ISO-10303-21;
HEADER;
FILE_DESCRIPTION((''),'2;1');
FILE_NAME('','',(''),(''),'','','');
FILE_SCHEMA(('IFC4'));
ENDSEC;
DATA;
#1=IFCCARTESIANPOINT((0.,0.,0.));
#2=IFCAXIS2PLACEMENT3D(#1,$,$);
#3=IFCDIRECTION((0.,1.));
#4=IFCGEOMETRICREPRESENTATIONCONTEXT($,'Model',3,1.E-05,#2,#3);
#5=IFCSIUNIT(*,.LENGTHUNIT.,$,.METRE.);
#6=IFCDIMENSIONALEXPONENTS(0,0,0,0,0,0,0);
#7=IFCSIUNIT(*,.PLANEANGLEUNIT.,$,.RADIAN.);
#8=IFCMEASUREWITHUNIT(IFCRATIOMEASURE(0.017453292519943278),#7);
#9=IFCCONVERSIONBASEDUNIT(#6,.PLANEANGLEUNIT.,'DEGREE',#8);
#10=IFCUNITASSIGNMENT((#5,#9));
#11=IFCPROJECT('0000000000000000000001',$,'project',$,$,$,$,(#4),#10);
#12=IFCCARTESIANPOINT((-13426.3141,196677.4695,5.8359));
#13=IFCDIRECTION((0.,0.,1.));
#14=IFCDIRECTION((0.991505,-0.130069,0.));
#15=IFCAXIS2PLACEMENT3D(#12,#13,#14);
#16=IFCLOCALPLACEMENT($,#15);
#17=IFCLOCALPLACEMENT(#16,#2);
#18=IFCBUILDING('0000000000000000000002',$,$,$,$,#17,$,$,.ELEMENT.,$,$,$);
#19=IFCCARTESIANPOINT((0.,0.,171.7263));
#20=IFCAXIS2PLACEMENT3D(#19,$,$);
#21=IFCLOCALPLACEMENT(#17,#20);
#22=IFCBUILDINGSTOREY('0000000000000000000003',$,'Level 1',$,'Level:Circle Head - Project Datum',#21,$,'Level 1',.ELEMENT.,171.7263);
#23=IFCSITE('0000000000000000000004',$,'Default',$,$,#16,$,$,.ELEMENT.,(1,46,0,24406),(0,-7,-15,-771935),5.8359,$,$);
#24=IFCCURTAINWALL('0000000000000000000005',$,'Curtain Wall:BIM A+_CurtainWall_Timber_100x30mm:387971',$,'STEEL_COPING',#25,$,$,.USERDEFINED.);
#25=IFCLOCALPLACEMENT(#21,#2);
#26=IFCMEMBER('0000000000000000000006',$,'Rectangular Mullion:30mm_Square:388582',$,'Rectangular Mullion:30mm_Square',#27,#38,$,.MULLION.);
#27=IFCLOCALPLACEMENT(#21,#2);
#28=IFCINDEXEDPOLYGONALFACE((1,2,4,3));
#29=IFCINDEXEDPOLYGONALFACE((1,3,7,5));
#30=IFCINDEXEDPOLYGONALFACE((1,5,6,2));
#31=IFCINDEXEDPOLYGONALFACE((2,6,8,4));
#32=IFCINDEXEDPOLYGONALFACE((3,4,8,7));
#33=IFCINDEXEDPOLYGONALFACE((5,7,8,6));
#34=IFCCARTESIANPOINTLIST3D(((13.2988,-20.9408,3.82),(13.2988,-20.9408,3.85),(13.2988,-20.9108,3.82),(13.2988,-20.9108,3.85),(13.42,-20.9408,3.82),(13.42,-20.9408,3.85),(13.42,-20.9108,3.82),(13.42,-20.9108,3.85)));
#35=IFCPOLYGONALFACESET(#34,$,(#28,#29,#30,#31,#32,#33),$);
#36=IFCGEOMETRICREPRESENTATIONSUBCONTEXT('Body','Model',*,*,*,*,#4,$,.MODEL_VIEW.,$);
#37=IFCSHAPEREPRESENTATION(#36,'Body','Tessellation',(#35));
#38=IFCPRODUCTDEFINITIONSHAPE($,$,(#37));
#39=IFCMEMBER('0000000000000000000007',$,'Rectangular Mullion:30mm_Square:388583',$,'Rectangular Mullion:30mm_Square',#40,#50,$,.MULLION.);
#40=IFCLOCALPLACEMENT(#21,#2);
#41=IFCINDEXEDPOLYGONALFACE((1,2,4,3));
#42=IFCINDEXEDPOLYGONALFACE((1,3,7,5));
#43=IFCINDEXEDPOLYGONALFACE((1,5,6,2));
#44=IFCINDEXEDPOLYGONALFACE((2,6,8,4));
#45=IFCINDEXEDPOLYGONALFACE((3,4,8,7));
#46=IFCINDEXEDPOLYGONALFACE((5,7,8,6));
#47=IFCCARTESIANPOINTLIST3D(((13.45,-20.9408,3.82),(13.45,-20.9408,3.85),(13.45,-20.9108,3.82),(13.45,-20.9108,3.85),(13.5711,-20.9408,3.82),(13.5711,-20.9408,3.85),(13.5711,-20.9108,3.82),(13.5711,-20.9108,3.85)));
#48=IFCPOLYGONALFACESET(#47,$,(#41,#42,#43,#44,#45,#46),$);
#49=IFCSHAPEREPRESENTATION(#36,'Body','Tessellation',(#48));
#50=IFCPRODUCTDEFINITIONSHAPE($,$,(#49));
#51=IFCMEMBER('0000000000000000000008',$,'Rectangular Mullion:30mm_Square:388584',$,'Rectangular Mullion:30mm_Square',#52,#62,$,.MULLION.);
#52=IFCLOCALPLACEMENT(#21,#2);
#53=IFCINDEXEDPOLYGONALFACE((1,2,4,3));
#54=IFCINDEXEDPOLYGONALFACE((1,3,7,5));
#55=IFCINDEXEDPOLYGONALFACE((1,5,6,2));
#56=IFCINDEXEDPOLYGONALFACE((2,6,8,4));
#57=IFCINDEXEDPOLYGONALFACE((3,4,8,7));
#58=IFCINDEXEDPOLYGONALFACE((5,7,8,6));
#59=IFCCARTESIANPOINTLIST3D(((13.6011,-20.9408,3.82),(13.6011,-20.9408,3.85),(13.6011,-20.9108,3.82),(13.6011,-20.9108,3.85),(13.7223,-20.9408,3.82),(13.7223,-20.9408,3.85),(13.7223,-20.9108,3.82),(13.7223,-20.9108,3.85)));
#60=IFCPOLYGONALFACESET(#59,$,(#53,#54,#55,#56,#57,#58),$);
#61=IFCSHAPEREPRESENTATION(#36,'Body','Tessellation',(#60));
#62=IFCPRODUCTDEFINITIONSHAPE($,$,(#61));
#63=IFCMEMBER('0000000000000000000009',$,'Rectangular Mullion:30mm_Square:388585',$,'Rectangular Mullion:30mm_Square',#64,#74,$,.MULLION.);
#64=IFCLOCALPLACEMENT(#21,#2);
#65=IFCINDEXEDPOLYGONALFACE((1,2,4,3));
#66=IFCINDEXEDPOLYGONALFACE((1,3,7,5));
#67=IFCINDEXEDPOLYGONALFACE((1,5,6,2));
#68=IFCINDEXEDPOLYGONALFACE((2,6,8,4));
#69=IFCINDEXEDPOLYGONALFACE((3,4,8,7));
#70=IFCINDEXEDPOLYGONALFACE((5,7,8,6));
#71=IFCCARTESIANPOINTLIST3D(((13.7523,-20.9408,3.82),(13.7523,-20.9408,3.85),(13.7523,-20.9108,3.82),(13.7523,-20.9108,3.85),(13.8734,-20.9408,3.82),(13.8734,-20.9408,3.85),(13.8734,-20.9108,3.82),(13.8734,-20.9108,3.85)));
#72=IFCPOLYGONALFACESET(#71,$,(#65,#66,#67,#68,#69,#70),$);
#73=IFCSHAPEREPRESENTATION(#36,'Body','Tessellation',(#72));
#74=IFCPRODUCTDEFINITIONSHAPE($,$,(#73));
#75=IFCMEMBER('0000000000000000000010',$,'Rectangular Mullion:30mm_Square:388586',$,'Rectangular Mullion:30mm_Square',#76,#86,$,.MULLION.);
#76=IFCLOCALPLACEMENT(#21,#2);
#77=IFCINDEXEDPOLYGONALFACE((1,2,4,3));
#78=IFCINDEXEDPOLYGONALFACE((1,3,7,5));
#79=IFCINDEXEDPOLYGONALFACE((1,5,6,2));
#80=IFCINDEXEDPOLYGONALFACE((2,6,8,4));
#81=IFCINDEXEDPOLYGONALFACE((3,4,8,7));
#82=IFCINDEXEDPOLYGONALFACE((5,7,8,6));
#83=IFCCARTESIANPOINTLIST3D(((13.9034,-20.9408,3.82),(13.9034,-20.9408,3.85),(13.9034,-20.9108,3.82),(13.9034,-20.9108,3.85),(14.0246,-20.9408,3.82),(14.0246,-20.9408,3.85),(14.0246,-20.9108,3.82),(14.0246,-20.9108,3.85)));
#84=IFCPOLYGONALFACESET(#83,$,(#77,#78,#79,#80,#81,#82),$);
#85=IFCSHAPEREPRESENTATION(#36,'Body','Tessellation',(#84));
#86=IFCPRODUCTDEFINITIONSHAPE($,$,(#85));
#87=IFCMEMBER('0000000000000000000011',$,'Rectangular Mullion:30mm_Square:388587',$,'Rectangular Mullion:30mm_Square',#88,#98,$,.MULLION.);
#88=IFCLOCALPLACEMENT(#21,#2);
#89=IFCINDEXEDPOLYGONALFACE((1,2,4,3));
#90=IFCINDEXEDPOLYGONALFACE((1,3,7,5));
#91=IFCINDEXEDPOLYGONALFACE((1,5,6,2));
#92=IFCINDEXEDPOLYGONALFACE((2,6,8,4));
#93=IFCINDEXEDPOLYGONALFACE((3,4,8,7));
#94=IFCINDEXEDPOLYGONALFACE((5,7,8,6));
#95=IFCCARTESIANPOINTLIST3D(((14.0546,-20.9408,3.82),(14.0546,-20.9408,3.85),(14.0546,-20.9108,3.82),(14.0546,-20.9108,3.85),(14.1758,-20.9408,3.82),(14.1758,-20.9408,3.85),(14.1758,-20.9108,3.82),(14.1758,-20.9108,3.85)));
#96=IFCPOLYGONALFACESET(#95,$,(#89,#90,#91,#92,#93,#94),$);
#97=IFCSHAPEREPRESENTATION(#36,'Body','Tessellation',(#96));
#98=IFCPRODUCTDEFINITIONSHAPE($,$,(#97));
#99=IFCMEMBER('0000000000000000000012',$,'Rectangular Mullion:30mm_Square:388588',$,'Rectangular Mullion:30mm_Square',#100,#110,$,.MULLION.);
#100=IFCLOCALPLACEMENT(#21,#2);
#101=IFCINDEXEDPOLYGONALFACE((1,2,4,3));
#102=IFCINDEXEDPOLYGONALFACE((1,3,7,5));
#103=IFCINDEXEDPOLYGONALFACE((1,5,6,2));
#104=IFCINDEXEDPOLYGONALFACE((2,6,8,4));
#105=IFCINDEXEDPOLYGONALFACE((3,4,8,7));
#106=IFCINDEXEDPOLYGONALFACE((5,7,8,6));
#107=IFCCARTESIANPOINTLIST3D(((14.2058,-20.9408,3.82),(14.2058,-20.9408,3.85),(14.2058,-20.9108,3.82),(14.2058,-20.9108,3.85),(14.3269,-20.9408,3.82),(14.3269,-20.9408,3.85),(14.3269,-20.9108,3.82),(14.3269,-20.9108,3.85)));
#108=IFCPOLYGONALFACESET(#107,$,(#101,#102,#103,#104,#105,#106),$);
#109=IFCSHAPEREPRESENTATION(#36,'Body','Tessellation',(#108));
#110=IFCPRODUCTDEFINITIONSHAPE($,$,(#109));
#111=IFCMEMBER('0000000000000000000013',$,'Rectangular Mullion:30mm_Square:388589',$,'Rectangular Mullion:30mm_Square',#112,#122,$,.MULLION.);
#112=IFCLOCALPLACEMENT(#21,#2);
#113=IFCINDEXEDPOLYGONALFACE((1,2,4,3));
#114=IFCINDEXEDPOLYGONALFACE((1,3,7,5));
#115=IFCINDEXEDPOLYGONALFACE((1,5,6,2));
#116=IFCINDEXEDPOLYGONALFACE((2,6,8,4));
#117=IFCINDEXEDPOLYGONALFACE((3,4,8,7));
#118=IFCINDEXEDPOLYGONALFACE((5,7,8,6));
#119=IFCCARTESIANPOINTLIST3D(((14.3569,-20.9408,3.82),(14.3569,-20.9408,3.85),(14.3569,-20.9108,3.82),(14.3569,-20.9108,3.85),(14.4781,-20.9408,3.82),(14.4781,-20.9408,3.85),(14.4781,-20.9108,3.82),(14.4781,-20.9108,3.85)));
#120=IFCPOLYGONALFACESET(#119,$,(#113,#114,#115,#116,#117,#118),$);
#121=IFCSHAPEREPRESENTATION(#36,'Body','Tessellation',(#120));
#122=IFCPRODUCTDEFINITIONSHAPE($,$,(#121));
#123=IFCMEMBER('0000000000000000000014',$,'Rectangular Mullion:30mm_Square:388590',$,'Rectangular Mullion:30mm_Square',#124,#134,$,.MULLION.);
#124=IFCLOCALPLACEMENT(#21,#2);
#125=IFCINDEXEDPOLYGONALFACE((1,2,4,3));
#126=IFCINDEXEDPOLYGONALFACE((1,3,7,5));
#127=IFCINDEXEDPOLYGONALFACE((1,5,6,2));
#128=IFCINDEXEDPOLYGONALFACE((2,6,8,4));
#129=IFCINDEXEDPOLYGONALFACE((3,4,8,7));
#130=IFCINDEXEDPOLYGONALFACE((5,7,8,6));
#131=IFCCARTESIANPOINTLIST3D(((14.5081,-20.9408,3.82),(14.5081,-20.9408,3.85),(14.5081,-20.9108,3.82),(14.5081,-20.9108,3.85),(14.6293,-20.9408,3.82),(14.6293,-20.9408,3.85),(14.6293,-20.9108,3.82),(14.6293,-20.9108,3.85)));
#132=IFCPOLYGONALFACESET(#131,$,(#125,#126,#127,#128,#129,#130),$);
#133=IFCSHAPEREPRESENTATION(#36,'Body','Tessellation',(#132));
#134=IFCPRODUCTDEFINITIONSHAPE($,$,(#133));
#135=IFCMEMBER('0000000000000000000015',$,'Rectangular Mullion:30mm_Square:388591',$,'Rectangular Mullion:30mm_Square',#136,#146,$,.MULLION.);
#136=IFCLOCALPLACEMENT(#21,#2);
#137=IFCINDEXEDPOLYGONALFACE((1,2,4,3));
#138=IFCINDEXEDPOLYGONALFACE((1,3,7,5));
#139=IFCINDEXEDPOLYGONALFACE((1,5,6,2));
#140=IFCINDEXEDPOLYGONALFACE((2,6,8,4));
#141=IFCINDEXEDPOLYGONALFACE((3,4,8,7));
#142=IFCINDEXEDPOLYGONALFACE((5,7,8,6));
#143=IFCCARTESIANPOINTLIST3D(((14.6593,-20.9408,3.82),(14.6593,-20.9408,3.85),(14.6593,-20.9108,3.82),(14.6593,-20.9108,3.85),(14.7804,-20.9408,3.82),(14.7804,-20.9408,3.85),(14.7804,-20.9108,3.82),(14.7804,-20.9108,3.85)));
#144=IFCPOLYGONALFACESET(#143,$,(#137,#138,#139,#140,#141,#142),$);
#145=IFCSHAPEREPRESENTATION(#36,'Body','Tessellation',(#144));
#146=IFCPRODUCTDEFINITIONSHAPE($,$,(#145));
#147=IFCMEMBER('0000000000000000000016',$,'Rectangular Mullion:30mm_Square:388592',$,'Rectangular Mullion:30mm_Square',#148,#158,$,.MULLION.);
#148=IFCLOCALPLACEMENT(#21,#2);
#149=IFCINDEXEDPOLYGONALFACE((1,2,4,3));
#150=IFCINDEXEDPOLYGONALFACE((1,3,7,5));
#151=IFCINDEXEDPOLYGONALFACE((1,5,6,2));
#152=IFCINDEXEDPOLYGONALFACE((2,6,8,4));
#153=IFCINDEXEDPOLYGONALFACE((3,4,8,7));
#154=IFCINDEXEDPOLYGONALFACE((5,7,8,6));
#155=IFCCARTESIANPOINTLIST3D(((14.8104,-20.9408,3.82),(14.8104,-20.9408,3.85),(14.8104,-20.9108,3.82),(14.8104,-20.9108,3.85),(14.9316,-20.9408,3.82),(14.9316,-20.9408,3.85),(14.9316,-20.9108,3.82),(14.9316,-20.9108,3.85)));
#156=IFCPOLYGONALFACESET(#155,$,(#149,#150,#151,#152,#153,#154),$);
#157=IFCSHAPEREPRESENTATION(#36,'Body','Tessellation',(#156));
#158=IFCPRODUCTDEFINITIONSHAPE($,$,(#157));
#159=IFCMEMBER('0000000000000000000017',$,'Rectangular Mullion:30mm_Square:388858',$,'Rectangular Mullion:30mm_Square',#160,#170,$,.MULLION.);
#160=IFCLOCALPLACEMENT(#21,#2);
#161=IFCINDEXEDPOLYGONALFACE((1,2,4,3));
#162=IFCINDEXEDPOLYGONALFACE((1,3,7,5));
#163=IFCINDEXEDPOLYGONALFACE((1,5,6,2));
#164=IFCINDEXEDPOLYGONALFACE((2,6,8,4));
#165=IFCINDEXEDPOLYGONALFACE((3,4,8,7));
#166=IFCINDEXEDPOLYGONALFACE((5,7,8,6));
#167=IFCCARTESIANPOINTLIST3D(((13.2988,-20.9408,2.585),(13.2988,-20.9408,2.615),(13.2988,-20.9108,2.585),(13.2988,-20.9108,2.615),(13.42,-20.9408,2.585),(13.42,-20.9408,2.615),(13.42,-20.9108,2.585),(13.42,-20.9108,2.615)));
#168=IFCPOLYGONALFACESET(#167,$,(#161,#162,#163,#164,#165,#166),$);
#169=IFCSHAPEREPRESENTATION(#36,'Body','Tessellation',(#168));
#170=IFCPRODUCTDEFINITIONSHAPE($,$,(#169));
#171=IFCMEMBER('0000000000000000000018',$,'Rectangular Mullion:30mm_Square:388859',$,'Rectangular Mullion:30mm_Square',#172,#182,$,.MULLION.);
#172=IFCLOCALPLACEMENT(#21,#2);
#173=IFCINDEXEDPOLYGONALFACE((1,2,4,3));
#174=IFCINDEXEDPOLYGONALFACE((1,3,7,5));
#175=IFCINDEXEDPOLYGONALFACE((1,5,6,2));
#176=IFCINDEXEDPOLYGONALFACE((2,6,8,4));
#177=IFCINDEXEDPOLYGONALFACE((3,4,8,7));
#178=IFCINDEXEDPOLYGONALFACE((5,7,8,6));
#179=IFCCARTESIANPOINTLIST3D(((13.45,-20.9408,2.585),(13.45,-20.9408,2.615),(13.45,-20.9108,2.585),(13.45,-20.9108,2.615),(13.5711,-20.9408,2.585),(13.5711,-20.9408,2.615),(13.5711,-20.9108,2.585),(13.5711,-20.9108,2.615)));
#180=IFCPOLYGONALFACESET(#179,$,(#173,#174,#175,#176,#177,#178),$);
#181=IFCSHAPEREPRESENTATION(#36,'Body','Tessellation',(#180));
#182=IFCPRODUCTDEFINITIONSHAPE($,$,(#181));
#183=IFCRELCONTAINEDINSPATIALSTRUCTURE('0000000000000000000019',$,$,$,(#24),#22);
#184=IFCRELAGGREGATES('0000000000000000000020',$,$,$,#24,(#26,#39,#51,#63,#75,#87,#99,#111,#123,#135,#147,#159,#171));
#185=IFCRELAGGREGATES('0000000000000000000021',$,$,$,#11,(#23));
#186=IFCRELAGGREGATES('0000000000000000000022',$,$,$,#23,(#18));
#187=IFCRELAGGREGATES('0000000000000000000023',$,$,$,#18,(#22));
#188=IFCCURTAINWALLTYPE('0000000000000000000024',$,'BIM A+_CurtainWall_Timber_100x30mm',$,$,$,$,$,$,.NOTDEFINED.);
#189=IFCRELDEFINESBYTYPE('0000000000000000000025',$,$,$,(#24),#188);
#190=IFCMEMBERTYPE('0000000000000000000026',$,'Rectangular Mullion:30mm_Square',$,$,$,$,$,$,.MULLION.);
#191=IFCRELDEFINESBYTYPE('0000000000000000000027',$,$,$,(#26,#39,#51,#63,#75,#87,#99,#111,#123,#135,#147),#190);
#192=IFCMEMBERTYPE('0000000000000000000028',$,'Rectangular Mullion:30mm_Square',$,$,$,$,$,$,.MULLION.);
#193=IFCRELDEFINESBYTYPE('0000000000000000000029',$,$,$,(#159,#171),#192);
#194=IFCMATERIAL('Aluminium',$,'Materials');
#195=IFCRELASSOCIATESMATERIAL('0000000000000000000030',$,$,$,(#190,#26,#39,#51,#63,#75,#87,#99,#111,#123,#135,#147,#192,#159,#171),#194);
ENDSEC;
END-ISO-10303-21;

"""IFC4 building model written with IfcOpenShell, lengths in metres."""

from ifc_helpers import new_model, entity, si_unit, converted_unit, direction, frame, origin, place, context, subcontext, project, spatial, indexed_curve, outline, extrude, source, transform, mapped, material, type_object, type_shapes, element, aggregate, save


model = new_model("IFC4")

# Units and contexts
model_context = context("Model", 3, precision=1e-05, world=origin(), true_north=direction((0.0, 1.0)))
body_context = subcontext(model_context, "Body", "Model", "MODEL_VIEW")
ifc_project = project(units=[si_unit("LENGTHUNIT", "METRE"), converted_unit("PLANEANGLEUNIT", "DEGREE", entity("IfcRatioMeasure", 0.017453292519943278), si_unit("PLANEANGLEUNIT", "RADIAN"), dimensions=[0, 0, 0, 0, 0, 0, 0])], contexts=[model_context])

# Site, building, storey
site_placement = place(None, frame((-13426.3141, 196677.4695, 5.8359), z_axis=(0.0, 0.0, 1.0), x_axis=(0.991505, -0.130069, 0.0)))
site = spatial("IfcSite", under=ifc_project, at=site_placement, Name="Default", CompositionType="ELEMENT", RefLatitude=(1, 46, 0, 24406), RefLongitude=(0, -7, -15, -771935), RefElevation=5.8359)
building_placement = place(site_placement, origin())
building = spatial("IfcBuilding", under=site, at=building_placement, CompositionType="ELEMENT")
storey_placement = place(building_placement, frame((0.0, 0.0, 171.7263)))
storey = spatial("IfcBuildingStorey", under=building, at=storey_placement, Name="Level 1", ObjectType="Level:Circle Head - Project Datum", LongName="Level 1", CompositionType="ELEMENT", Elevation=171.7263)

# Curtain wall, members
curtain_wall_type = type_object("IfcCurtainWallType", Name="BIM A+_CurtainWall_Timber_100x30mm", PredefinedType="NOTDEFINED")
curtain_wall_placement = place(storey_placement, frame((0.0, 0.0, -171.7263)))
curtain_wall = element("IfcCurtainWall", 1, at=curtain_wall_placement, inside=storey, type_object=curtain_wall_type, Name="Curtain Wall:BIM A+_CurtainWall_Timber_100x30mm:387971", ObjectType="STEEL_COPING", PredefinedType="USERDEFINED")
ifc_material_1 = material(Name="Aluminium", Category="Materials")
member_type_1 = type_object("IfcMemberType", Name="Rectangular Mullion:30mm_Square", PredefinedType="MULLION", material=ifc_material_1)
shared_shape_1 = source(origin(), body_context, "Body", "SweptSolid", [
    extrude(outline(indexed_curve([(-0.015, -0.015), (0.015, -0.015), (0.015, 0.015), (-0.015, 0.015), (-0.015, -0.015)], self_intersect=False)), frame((-0.015, 0.0, -0.1212), z_axis=(0.0, 0.0, 1.0), x_axis=(0.0, -1.0, 0.0)), (0.0, 0.0, 1.0), 0.1212),
])
type_shapes(member_type_1, [shared_shape_1])
member_1_placement = place(curtain_wall_placement, frame((13.42, -20.9258, 175.5763), z_axis=(1.0, 0.0, 0.0), x_axis=(0.0, 0.0, 1.0)))
member_1 = element("IfcMember", 2, at=member_1_placement, type_object=member_type_1, material=ifc_material_1, Name="Rectangular Mullion:30mm_Square:388582", ObjectType="Rectangular Mullion:30mm_Square", PredefinedType="MULLION", context=body_context, shape_type="MappedRepresentation", body=[
    mapped(shared_shape_1, transform((0.0, 0.0, 0.0), scale=1.0)),
])
member_2_placement = place(curtain_wall_placement, frame((13.5711, -20.9258, 175.5763), z_axis=(1.0, 0.0, 0.0), x_axis=(0.0, 0.0, 1.0)))
member_2 = element("IfcMember", 3, at=member_2_placement, type_object=member_type_1, material=ifc_material_1, Name="Rectangular Mullion:30mm_Square:388583", ObjectType="Rectangular Mullion:30mm_Square", PredefinedType="MULLION", context=body_context, shape_type="MappedRepresentation", body=[
    mapped(shared_shape_1, transform((0.0, 0.0, 0.0), scale=1.0)),
])
member_3_placement = place(curtain_wall_placement, frame((13.7223, -20.9258, 175.5763), z_axis=(1.0, 0.0, 0.0), x_axis=(0.0, 0.0, 1.0)))
member_3 = element("IfcMember", 4, at=member_3_placement, type_object=member_type_1, material=ifc_material_1, Name="Rectangular Mullion:30mm_Square:388584", ObjectType="Rectangular Mullion:30mm_Square", PredefinedType="MULLION", context=body_context, shape_type="MappedRepresentation", body=[
    mapped(shared_shape_1, transform((0.0, 0.0, 0.0), scale=1.0)),
])
member_4_placement = place(curtain_wall_placement, frame((13.8734, -20.9258, 175.5763), z_axis=(1.0, 0.0, 0.0), x_axis=(0.0, 0.0, 1.0)))
member_4 = element("IfcMember", 5, at=member_4_placement, type_object=member_type_1, material=ifc_material_1, Name="Rectangular Mullion:30mm_Square:388585", ObjectType="Rectangular Mullion:30mm_Square", PredefinedType="MULLION", context=body_context, shape_type="MappedRepresentation", body=[
    mapped(shared_shape_1, transform((0.0, 0.0, 0.0), scale=1.0)),
])
member_5_placement = place(curtain_wall_placement, frame((14.0246, -20.9258, 175.5763), z_axis=(1.0, 0.0, 0.0), x_axis=(0.0, 0.0, 1.0)))
member_5 = element("IfcMember", 6, at=member_5_placement, type_object=member_type_1, material=ifc_material_1, Name="Rectangular Mullion:30mm_Square:388586", ObjectType="Rectangular Mullion:30mm_Square", PredefinedType="MULLION", context=body_context, shape_type="MappedRepresentation", body=[
    mapped(shared_shape_1, transform((0.0, 0.0, 0.0), scale=1.0)),
])
member_6_placement = place(curtain_wall_placement, frame((14.1758, -20.9258, 175.5763), z_axis=(1.0, 0.0, 0.0), x_axis=(0.0, 0.0, 1.0)))
member_6 = element("IfcMember", 7, at=member_6_placement, type_object=member_type_1, material=ifc_material_1, Name="Rectangular Mullion:30mm_Square:388587", ObjectType="Rectangular Mullion:30mm_Square", PredefinedType="MULLION", context=body_context, shape_type="MappedRepresentation", body=[
    mapped(shared_shape_1, transform((0.0, 0.0, 0.0), scale=1.0)),
])
member_7_placement = place(curtain_wall_placement, frame((14.3269, -20.9258, 175.5763), z_axis=(1.0, 0.0, 0.0), x_axis=(0.0, 0.0, 1.0)))
member_7 = element("IfcMember", 8, at=member_7_placement, type_object=member_type_1, material=ifc_material_1, Name="Rectangular Mullion:30mm_Square:388588", ObjectType="Rectangular Mullion:30mm_Square", PredefinedType="MULLION", context=body_context, shape_type="MappedRepresentation", body=[
    mapped(shared_shape_1, transform((0.0, 0.0, 0.0), scale=1.0)),
])
member_8_placement = place(curtain_wall_placement, frame((14.4781, -20.9258, 175.5763), z_axis=(1.0, 0.0, 0.0), x_axis=(0.0, 0.0, 1.0)))
member_8 = element("IfcMember", 9, at=member_8_placement, type_object=member_type_1, material=ifc_material_1, Name="Rectangular Mullion:30mm_Square:388589", ObjectType="Rectangular Mullion:30mm_Square", PredefinedType="MULLION", context=body_context, shape_type="MappedRepresentation", body=[
    mapped(shared_shape_1, transform((0.0, 0.0, 0.0), scale=1.0)),
])
member_9_placement = place(curtain_wall_placement, frame((14.6293, -20.9258, 175.5763), z_axis=(1.0, 0.0, 0.0), x_axis=(0.0, 0.0, 1.0)))
member_9 = element("IfcMember", 10, at=member_9_placement, type_object=member_type_1, material=ifc_material_1, Name="Rectangular Mullion:30mm_Square:388590", ObjectType="Rectangular Mullion:30mm_Square", PredefinedType="MULLION", context=body_context, shape_type="MappedRepresentation", body=[
    mapped(shared_shape_1, transform((0.0, 0.0, 0.0), scale=1.0)),
])
member_10_placement = place(curtain_wall_placement, frame((14.7804, -20.9258, 175.5763), z_axis=(1.0, 0.0, 0.0), x_axis=(0.0, 0.0, 1.0)))
member_10 = element("IfcMember", 11, at=member_10_placement, type_object=member_type_1, material=ifc_material_1, Name="Rectangular Mullion:30mm_Square:388591", ObjectType="Rectangular Mullion:30mm_Square", PredefinedType="MULLION", context=body_context, shape_type="MappedRepresentation", body=[
    mapped(shared_shape_1, transform((0.0, 0.0, 0.0), scale=1.0)),
])
member_11_placement = place(curtain_wall_placement, frame((14.9316, -20.9258, 175.5763), z_axis=(1.0, 0.0, 0.0), x_axis=(0.0, 0.0, 1.0)))
member_11 = element("IfcMember", 12, at=member_11_placement, type_object=member_type_1, material=ifc_material_1, Name="Rectangular Mullion:30mm_Square:388592", ObjectType="Rectangular Mullion:30mm_Square", PredefinedType="MULLION", context=body_context, shape_type="MappedRepresentation", body=[
    mapped(shared_shape_1, transform((0.0, 0.0, 0.0), scale=1.0)),
])
member_type_2 = type_object("IfcMemberType", Name="Rectangular Mullion:30mm_Square", PredefinedType="MULLION", material=ifc_material_1)
shared_shape_2 = source(origin(), body_context, "Body", "SweptSolid", [
    extrude(outline(indexed_curve([(-0.015, -0.015), (0.015, -0.015), (0.015, 0.015), (-0.015, 0.015), (-0.015, -0.015)], self_intersect=False)), frame((0.0, 0.0, -0.1212), z_axis=(0.0, 0.0, 1.0), x_axis=(0.0, -1.0, 0.0)), (0.0, 0.0, 1.0), 0.1212),
])
type_shapes(member_type_2, [shared_shape_2])
member_12_placement = place(curtain_wall_placement, frame((13.42, -20.9258, 174.3263), z_axis=(1.0, 0.0, 0.0), x_axis=(0.0, 0.0, 1.0)))
member_12 = element("IfcMember", 13, at=member_12_placement, type_object=member_type_2, material=ifc_material_1, Name="Rectangular Mullion:30mm_Square:388858", ObjectType="Rectangular Mullion:30mm_Square", PredefinedType="MULLION", context=body_context, shape_type="MappedRepresentation", body=[
    mapped(shared_shape_2, transform((0.0, 0.0, 0.0), scale=1.0)),
])
member_13_placement = place(curtain_wall_placement, frame((13.5711, -20.9258, 174.3263), z_axis=(1.0, 0.0, 0.0), x_axis=(0.0, 0.0, 1.0)))
member_13 = element("IfcMember", 14, at=member_13_placement, type_object=member_type_2, material=ifc_material_1, Name="Rectangular Mullion:30mm_Square:388859", ObjectType="Rectangular Mullion:30mm_Square", PredefinedType="MULLION", context=body_context, shape_type="MappedRepresentation", body=[
    mapped(shared_shape_2, transform((0.0, 0.0, 0.0), scale=1.0)),
])
aggregate(curtain_wall, [member_1, member_2, member_3, member_4, member_5, member_6, member_7, member_8, member_9, member_10, member_11, member_12, member_13])

save(model, "model.ifc")
